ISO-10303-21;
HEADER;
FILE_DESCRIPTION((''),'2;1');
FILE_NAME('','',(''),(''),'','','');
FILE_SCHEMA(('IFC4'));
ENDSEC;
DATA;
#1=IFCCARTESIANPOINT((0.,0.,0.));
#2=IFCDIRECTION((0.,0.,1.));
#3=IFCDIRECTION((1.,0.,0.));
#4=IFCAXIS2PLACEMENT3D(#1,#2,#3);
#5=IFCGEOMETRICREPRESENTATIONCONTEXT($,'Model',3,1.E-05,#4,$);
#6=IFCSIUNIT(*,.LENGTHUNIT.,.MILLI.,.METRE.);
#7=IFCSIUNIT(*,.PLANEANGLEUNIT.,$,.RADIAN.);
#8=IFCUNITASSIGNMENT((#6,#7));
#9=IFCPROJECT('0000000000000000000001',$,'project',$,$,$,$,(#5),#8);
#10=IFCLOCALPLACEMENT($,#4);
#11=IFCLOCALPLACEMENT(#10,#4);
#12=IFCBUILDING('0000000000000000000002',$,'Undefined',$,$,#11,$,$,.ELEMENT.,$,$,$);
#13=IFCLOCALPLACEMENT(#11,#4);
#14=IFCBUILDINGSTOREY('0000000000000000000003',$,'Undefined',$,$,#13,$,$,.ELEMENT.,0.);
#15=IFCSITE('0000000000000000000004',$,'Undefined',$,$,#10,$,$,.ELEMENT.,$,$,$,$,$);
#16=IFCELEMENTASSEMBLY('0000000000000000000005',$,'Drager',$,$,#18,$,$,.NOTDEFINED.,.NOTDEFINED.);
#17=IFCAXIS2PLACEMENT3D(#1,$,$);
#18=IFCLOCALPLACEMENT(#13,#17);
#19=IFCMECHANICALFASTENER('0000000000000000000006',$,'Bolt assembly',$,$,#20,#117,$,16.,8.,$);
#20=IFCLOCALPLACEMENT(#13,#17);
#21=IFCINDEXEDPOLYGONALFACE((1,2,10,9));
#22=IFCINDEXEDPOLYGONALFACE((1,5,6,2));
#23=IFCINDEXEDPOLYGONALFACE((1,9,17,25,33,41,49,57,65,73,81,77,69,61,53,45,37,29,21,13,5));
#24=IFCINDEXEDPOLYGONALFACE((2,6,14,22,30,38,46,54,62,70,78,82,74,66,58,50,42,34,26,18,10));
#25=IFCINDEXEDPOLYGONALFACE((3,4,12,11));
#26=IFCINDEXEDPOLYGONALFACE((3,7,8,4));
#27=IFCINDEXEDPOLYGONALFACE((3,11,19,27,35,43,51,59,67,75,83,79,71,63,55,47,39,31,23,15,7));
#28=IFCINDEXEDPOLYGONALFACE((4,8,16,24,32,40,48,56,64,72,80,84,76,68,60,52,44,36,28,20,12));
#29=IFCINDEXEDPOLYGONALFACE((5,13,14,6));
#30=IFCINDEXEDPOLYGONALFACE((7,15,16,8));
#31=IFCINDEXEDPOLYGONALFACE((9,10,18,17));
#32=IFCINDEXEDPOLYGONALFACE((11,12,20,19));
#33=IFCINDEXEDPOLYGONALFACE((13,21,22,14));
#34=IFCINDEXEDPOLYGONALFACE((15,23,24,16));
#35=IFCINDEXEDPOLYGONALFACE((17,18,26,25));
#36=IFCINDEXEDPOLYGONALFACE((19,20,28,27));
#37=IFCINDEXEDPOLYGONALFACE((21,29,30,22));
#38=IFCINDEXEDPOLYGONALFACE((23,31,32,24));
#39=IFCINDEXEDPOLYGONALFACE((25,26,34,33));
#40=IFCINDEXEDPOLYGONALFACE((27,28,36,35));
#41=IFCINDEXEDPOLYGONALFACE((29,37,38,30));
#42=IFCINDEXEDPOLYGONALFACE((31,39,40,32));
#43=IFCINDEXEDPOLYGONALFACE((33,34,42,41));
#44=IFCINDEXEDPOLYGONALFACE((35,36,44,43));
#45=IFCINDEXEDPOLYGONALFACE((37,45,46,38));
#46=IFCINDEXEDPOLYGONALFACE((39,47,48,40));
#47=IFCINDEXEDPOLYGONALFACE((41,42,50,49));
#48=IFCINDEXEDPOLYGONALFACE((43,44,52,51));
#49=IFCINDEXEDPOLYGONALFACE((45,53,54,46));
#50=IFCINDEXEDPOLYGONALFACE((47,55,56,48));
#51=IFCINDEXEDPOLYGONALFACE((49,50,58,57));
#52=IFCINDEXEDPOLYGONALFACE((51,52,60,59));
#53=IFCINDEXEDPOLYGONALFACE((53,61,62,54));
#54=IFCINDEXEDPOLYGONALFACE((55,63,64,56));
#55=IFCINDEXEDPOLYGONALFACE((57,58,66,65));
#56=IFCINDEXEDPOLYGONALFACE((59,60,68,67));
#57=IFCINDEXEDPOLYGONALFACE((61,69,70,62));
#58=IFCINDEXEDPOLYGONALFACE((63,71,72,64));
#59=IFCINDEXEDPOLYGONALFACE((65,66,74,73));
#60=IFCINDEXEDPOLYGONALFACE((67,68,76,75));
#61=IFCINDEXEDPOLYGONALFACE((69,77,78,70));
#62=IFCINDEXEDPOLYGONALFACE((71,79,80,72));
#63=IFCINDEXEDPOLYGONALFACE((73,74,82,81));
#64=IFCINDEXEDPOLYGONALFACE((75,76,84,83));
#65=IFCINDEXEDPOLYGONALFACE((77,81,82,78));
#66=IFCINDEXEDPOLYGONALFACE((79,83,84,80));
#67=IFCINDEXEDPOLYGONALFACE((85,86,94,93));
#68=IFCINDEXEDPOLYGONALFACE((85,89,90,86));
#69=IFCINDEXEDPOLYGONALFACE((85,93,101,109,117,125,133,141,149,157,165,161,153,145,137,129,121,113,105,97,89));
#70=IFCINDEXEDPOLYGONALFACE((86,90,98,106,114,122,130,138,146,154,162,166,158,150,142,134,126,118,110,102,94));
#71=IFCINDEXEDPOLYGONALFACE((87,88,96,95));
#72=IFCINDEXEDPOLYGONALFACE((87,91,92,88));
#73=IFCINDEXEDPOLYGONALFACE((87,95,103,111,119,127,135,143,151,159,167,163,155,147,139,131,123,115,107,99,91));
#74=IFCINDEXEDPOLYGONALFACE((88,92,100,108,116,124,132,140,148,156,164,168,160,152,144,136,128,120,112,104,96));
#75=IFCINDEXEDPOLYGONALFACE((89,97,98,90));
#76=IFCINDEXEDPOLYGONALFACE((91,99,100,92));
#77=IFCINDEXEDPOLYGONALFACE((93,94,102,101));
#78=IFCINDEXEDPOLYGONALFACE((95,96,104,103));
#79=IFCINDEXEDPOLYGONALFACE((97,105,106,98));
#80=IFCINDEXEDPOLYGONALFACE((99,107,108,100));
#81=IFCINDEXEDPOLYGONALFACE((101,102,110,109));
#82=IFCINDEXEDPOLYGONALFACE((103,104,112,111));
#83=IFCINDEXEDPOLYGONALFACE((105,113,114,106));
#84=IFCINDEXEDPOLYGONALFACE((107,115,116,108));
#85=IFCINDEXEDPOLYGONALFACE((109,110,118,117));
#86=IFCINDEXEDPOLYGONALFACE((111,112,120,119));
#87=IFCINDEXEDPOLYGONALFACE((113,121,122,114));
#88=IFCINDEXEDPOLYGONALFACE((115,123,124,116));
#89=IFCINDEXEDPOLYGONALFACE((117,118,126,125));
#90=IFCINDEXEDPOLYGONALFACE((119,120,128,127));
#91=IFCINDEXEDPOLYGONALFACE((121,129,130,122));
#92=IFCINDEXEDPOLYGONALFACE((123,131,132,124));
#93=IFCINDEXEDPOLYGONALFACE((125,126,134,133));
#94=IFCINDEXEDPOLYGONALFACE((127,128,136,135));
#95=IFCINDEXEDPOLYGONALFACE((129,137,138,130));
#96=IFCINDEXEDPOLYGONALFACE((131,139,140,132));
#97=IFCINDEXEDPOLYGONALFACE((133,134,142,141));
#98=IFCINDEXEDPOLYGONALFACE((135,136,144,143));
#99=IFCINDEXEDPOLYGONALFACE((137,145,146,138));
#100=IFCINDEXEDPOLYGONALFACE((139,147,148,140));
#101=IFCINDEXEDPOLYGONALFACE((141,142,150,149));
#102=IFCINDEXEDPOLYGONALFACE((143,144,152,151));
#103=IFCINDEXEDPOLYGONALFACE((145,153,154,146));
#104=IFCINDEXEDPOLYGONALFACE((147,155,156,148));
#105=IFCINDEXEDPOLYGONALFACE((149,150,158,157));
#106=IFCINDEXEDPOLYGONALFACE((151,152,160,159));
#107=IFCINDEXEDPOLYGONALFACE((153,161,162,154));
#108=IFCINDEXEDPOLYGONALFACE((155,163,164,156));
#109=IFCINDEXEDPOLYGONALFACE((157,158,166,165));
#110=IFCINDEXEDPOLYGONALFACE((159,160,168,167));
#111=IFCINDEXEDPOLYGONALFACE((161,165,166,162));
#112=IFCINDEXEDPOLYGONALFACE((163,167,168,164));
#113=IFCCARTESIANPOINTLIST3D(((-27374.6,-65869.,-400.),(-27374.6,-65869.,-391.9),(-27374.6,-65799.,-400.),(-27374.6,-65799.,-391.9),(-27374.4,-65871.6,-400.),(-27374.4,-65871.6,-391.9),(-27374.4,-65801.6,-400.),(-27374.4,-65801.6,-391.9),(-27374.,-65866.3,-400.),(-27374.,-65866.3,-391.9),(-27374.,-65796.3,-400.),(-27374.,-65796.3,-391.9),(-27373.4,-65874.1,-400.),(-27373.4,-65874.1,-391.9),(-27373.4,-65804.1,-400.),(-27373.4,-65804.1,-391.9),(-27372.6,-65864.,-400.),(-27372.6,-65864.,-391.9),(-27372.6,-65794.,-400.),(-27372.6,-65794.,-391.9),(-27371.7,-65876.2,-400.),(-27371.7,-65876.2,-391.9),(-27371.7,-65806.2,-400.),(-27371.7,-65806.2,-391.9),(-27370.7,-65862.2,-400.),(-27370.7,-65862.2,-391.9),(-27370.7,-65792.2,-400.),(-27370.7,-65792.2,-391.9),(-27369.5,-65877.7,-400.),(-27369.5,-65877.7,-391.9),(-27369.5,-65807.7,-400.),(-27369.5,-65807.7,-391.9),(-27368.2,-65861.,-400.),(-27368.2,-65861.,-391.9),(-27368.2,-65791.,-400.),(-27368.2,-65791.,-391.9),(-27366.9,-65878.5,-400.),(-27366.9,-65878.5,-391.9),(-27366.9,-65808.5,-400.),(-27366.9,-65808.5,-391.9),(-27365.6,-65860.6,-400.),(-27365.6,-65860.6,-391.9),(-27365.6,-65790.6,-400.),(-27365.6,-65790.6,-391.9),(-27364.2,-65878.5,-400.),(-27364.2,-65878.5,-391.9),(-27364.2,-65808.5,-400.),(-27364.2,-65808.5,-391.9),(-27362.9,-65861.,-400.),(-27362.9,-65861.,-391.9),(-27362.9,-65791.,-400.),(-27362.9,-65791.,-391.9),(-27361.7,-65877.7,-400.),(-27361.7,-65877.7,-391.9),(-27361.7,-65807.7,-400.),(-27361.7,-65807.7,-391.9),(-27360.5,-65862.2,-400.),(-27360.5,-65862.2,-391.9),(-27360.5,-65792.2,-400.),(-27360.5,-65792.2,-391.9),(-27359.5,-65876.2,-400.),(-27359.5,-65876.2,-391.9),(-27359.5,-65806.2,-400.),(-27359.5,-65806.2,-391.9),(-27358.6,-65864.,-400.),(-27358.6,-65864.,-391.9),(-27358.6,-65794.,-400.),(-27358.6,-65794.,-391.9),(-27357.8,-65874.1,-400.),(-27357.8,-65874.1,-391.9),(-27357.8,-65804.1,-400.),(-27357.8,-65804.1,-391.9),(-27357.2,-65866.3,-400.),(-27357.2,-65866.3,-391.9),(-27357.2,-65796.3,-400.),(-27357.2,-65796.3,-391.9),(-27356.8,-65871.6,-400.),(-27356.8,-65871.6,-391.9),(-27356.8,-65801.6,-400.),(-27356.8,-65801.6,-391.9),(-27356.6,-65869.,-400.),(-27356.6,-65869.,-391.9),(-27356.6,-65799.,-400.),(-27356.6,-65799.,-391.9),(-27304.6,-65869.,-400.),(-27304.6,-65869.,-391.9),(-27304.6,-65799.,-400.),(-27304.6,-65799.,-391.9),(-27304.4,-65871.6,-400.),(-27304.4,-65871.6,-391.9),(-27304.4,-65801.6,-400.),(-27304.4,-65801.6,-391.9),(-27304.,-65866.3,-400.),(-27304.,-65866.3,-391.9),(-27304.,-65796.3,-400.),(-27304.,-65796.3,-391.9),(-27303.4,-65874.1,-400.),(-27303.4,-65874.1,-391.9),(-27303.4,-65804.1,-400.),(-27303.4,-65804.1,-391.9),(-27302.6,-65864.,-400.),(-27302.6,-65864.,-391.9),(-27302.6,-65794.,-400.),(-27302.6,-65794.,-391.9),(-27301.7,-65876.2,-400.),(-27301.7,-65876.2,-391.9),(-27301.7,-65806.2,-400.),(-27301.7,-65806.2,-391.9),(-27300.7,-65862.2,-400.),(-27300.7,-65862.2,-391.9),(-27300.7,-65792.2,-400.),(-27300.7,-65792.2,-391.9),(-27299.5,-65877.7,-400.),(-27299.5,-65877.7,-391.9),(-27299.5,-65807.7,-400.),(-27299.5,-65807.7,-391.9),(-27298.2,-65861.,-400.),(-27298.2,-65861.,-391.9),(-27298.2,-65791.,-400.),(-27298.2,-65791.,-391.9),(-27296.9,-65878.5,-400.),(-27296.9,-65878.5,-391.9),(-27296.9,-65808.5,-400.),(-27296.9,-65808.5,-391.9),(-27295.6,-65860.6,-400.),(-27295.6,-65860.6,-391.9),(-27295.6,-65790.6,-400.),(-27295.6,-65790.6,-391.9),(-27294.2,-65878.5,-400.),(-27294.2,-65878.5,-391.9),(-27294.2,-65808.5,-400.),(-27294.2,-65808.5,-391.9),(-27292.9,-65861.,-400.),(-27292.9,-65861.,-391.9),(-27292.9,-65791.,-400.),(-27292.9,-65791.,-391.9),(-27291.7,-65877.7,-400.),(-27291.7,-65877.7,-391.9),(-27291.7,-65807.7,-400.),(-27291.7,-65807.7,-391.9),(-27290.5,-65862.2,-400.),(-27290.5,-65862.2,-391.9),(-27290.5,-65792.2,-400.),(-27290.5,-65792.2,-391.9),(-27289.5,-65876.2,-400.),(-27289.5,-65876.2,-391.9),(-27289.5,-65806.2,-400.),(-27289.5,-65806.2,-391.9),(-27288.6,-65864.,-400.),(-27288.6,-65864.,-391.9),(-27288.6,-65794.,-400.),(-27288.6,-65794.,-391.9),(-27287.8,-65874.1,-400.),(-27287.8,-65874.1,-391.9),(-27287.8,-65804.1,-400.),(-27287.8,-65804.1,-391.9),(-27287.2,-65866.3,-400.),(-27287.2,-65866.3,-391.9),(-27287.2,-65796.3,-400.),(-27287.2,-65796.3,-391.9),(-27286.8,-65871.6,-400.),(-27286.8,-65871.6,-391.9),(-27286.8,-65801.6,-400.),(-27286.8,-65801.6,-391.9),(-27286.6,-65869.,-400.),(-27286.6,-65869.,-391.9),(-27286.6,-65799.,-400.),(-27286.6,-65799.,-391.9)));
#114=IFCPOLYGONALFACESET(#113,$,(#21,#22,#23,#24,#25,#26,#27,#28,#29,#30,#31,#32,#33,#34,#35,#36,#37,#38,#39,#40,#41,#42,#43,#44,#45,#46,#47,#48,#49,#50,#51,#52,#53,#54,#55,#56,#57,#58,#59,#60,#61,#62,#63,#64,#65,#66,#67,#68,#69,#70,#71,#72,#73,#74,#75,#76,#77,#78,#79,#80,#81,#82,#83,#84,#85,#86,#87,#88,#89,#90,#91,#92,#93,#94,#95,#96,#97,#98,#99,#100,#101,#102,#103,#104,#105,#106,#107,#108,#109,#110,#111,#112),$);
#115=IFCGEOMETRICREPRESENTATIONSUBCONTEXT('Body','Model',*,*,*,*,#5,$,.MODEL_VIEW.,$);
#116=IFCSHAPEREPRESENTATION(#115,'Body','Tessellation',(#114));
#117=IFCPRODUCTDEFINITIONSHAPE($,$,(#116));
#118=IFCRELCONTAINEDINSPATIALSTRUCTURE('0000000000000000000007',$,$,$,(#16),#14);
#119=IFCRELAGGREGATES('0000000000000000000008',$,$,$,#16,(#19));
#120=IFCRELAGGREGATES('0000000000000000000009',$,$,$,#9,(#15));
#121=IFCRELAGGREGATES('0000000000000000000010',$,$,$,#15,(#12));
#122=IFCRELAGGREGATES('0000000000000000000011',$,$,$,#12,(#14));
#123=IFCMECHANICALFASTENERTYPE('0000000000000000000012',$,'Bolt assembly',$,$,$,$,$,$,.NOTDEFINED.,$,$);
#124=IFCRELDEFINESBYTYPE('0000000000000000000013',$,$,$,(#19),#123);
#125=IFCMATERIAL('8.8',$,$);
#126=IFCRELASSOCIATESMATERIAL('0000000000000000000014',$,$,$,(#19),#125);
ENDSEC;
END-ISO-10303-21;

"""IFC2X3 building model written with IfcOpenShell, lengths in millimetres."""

from ifc_helpers import new_model, si_unit, frame, origin_with_axes, origin_2d_with_axis, place, context, subcontext, project, spatial, circle, extrude, source, transform, mapped, material, type_object, element, aggregate, save


model = new_model("IFC2X3")

# Units and contexts
model_context = context("Model", 3, precision=1e-05, world=origin_with_axes())
body_context = subcontext(model_context, "Body", "Model", "MODEL_VIEW")
ifc_project = project(units=[si_unit("LENGTHUNIT", "METRE", prefix="MILLI"), si_unit("PLANEANGLEUNIT", "RADIAN")], contexts=[model_context])

# Site, building, storey
site_placement = place(None, origin_with_axes())
site = spatial("IfcSite", under=ifc_project, at=site_placement, Name="Undefined", CompositionType="ELEMENT")
building_placement = place(site_placement, origin_with_axes())
building = spatial("IfcBuilding", under=site, at=building_placement, Name="Undefined", CompositionType="ELEMENT")
storey_placement = place(building_placement, origin_with_axes())
storey = spatial("IfcBuildingStorey", under=building, at=storey_placement, Name="Undefined", CompositionType="ELEMENT", Elevation=0.0)

# Element assembly
assembly_1_placement = place(storey_placement, origin_with_axes())
assembly_1 = element("IfcElementAssembly", 1, at=assembly_1_placement, inside=storey, Name="Drager", AssemblyPlace="NOTDEFINED", PredefinedType="NOTDEFINED")

# Mechanical fastener
ifc_material_1 = material(Name="8.8")
mechanical_fastener_type = type_object("IfcMechanicalFastenerType", Name="Bolt assembly")
shared_shape_1 = source(origin_with_axes(), body_context, "Body", "SweptSolid", [
    extrude(circle(Radius=9.0, at=origin_2d_with_axis()), frame((0.0, -8.0, 0.0), z_axis=(0.0, 1.0, 0.0), x_axis=(1.0, 0.0, 0.0)), (0.0, 0.0, 1.0), 8.1),
])
mechanical_fastener_1_placement = place(assembly_1_placement, frame((-27330.6, -65869.6, -392.0), z_axis=(1.0, 0.0, 0.0), x_axis=(0.0, 1.0, 0.0)))
mechanical_fastener_1 = element("IfcMechanicalFastener", 2, at=mechanical_fastener_1_placement, type_object=mechanical_fastener_type, material=ifc_material_1, Name="Bolt assembly", NominalDiameter=16.0, NominalLength=8.0, context=body_context, shape_type="MappedRepresentation", body=[
    mapped(shared_shape_1, transform((0.0, 0.0, -35.0))),
    mapped(shared_shape_1, transform((70.0, 0.0, -35.0))),
    mapped(shared_shape_1, transform((0.0, 0.0, 35.0))),
    mapped(shared_shape_1, transform((70.0, 0.0, 35.0))),
])
aggregate(assembly_1, [mechanical_fastener_1])

save(model, "model.ifc")
